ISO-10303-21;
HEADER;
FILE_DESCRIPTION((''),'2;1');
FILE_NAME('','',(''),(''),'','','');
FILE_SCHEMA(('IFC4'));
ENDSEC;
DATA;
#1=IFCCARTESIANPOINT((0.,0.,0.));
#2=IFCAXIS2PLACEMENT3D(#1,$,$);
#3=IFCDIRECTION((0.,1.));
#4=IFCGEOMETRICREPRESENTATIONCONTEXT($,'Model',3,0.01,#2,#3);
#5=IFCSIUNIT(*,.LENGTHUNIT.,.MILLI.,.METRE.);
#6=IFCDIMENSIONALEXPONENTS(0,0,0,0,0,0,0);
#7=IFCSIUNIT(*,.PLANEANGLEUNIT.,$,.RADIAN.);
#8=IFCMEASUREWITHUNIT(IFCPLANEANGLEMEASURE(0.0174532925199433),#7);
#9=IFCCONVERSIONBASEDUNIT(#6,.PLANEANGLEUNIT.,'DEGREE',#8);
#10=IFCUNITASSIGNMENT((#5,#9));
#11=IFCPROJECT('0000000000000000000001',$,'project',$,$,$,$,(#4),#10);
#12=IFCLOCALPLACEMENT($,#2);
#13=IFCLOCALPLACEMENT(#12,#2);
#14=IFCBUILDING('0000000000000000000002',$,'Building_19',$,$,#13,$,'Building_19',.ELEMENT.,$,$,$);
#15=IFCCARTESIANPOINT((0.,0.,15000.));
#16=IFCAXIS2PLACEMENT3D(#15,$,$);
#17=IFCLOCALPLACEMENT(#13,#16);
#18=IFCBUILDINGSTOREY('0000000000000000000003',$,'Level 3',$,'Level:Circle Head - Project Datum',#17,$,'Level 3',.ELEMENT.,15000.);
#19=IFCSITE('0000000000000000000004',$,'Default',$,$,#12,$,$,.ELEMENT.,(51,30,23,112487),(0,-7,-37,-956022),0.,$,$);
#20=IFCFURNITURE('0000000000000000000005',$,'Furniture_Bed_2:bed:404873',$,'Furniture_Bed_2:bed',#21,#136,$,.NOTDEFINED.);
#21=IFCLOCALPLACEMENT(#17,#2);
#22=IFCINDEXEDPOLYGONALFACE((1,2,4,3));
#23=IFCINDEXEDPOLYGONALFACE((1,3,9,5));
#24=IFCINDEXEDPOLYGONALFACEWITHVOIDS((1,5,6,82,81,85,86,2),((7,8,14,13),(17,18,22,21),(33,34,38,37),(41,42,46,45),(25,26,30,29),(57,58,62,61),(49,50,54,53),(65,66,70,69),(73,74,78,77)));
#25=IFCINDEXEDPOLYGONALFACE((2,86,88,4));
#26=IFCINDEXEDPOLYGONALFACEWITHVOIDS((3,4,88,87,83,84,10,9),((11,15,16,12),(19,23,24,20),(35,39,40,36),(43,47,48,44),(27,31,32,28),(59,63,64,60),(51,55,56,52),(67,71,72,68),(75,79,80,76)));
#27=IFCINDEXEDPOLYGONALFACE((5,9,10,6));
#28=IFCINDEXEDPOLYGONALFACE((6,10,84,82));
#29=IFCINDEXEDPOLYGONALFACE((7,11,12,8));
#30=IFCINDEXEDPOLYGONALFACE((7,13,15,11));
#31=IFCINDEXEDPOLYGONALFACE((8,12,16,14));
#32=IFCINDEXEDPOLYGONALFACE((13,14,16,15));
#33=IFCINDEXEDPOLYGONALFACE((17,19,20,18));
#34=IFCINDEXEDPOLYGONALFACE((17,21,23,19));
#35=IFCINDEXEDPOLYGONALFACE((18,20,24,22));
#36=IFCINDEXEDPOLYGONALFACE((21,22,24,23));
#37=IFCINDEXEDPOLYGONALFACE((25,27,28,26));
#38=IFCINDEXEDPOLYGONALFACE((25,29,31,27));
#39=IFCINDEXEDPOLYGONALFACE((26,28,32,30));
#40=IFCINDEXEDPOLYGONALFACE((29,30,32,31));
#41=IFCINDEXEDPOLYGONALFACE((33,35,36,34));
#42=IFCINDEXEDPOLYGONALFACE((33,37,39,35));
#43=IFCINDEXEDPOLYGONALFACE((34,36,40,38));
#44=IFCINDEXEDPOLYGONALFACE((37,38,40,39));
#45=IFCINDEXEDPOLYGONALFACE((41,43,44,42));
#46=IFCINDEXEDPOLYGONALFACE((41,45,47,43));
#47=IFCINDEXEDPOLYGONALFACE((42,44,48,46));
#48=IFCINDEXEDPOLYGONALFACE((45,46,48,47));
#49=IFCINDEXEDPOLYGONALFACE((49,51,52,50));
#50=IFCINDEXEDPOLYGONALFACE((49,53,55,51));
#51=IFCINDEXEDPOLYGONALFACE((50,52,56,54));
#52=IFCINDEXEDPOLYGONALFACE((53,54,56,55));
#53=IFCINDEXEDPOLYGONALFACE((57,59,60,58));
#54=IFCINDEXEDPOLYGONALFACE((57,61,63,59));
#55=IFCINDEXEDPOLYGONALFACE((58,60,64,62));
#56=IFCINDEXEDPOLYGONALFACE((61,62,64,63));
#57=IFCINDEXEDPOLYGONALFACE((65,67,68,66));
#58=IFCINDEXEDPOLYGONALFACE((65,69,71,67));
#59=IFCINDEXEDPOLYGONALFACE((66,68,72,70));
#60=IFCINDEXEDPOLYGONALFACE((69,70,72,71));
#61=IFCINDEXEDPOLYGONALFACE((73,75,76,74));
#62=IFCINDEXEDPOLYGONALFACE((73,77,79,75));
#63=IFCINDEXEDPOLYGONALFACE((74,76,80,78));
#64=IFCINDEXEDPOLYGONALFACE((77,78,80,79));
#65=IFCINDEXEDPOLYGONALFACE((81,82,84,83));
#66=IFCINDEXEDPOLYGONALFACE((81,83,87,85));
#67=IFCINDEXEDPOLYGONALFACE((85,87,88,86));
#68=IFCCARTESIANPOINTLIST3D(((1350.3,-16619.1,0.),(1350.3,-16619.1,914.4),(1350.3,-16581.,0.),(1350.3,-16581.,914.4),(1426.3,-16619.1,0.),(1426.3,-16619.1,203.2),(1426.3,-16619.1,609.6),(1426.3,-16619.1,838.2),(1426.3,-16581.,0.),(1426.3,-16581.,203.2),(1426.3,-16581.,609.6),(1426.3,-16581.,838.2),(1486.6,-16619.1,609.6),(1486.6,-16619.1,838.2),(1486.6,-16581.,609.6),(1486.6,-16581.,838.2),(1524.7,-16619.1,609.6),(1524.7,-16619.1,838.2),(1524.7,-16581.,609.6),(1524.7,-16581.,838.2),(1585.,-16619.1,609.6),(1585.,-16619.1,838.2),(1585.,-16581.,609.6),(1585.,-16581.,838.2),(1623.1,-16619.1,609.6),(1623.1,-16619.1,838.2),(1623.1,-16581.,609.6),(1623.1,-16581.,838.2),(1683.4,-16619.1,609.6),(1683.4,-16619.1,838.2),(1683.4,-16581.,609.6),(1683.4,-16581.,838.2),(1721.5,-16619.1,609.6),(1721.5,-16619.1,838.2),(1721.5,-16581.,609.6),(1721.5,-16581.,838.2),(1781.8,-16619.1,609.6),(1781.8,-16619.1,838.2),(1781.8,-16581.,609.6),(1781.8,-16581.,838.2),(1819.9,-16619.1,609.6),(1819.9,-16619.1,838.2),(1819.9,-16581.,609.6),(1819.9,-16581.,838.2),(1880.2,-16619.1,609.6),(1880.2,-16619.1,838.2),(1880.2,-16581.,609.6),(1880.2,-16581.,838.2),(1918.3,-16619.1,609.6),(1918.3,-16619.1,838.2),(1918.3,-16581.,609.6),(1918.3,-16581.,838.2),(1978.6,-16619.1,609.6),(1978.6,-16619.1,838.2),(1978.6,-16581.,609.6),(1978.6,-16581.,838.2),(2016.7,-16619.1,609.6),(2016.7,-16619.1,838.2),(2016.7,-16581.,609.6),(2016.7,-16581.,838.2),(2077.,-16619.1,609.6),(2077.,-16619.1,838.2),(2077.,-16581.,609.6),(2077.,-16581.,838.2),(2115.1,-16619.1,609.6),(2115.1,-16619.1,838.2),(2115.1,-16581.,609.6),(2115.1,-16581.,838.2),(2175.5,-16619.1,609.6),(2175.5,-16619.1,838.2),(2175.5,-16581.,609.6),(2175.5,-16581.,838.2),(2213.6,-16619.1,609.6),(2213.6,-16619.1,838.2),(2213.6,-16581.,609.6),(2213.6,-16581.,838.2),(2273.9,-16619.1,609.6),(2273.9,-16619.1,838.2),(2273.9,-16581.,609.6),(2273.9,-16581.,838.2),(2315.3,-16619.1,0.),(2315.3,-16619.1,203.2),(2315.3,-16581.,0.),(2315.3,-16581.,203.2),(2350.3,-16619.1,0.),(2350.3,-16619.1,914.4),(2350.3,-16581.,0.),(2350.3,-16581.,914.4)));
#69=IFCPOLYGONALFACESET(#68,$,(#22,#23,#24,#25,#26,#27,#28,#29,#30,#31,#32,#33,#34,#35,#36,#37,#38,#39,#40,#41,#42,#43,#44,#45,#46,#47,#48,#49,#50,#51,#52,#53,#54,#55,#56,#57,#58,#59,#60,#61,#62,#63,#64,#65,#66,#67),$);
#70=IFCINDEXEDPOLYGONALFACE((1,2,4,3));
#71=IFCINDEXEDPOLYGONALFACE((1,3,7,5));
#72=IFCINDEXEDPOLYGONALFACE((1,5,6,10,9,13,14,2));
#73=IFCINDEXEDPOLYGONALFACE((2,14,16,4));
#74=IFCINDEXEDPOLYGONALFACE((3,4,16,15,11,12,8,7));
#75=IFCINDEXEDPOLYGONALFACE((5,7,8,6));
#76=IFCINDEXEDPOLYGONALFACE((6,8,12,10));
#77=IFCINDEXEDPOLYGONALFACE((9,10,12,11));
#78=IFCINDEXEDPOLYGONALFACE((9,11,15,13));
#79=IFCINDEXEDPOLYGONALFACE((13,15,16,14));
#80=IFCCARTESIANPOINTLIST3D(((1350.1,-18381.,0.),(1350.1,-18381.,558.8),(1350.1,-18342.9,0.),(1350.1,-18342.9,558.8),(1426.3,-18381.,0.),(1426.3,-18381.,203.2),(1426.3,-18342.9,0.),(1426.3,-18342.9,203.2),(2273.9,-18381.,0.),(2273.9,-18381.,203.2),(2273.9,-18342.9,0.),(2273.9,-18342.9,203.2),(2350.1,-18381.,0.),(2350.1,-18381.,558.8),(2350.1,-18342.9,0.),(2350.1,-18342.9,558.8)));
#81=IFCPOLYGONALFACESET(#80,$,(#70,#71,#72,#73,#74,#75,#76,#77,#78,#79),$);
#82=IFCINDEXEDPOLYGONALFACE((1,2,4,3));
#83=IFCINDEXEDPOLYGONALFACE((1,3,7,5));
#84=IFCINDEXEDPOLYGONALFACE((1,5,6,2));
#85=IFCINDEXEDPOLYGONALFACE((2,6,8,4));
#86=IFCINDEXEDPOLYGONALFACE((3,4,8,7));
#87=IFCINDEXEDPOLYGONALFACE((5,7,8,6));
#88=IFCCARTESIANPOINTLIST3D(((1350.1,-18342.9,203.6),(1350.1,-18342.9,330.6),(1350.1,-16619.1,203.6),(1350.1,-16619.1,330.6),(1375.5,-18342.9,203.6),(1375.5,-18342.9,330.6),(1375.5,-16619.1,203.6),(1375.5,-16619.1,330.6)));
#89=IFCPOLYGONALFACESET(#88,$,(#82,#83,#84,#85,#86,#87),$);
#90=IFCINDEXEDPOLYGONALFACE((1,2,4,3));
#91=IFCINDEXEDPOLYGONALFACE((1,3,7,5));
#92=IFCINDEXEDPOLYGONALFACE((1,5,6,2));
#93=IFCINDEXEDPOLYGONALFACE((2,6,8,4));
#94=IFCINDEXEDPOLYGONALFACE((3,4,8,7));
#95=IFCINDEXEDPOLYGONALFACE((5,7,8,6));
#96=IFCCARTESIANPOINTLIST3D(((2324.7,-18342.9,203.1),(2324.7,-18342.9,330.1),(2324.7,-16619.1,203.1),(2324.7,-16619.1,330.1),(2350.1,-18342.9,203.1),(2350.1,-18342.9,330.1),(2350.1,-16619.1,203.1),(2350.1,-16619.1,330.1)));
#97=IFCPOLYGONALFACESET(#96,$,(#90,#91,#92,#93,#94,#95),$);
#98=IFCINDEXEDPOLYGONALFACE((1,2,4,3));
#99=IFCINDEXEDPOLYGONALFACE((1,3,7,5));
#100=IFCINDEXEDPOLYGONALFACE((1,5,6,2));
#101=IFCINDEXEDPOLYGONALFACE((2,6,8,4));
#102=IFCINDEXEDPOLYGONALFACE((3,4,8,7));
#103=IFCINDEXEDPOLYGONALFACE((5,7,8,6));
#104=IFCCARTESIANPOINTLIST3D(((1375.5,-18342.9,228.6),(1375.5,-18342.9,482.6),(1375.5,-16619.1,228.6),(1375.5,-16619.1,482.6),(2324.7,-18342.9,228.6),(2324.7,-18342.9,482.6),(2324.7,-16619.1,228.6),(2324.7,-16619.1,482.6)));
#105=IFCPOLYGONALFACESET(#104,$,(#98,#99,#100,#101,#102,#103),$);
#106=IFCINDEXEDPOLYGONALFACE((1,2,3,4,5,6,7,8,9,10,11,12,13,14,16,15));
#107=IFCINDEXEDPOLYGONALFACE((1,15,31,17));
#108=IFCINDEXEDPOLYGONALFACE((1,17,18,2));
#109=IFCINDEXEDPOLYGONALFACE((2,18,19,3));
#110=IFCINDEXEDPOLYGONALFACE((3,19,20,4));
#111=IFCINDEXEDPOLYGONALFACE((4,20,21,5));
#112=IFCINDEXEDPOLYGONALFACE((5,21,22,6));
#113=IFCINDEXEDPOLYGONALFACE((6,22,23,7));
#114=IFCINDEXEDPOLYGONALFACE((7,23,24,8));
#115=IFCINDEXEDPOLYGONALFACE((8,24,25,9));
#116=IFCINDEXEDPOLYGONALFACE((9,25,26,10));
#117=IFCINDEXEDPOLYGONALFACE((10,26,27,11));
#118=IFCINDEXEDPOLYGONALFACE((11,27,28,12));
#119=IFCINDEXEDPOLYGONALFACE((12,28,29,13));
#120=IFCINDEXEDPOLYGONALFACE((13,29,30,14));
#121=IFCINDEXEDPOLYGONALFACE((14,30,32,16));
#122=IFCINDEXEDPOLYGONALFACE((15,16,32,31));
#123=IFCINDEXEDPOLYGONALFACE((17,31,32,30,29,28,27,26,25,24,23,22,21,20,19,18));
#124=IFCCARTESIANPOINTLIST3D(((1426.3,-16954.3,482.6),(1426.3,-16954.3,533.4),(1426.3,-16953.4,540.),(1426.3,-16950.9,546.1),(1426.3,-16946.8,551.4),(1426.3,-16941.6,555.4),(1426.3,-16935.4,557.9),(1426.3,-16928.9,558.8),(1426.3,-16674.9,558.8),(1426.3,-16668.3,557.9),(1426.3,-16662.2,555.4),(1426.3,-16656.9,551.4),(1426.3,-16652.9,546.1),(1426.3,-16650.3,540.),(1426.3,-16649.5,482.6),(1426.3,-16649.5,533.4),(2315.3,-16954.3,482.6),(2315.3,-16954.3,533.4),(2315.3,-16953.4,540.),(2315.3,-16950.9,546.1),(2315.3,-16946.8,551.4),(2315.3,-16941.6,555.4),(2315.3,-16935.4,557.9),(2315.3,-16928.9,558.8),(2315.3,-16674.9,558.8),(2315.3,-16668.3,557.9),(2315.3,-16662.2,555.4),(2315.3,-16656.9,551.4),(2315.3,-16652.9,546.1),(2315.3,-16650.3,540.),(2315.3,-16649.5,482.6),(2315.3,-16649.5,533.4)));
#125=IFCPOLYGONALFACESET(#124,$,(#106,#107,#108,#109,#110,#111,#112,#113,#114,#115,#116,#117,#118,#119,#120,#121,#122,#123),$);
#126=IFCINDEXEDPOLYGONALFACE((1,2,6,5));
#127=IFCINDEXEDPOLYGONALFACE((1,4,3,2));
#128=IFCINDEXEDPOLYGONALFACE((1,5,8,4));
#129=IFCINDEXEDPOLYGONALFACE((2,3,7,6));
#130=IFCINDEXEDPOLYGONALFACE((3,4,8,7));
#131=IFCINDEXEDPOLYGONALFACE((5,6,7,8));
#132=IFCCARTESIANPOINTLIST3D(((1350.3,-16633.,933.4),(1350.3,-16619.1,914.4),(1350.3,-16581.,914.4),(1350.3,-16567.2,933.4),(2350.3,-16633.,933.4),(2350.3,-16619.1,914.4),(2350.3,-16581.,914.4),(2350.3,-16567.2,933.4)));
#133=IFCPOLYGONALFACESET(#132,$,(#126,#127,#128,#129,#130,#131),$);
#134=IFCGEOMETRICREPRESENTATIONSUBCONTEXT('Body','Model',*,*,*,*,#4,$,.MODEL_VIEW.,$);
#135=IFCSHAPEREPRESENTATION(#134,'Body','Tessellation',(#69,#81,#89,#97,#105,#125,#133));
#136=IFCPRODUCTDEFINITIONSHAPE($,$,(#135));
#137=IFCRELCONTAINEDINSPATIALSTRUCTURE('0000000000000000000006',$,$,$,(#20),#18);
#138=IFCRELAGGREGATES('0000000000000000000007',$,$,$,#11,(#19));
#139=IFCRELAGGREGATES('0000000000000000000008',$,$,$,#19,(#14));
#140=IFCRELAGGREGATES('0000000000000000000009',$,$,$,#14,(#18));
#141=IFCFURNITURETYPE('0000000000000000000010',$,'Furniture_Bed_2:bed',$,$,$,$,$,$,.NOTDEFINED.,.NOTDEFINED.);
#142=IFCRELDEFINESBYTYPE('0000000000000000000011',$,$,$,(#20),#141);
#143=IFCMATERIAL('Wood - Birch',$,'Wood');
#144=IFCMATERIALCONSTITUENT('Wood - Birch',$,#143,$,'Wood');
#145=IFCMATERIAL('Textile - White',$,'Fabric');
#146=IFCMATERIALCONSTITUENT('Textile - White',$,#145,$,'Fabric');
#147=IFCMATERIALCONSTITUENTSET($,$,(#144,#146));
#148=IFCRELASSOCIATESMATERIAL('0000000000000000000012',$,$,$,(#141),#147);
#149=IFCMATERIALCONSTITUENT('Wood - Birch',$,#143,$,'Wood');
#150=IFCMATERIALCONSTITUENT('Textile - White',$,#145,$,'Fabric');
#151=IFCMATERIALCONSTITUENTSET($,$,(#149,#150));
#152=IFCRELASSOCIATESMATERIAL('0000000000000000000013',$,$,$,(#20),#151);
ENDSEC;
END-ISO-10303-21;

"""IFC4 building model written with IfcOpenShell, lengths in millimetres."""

from ifc_helpers import new_model, entity, si_unit, converted_unit, direction, frame, origin, place, context, subcontext, project, spatial, line, arc, indexed_curve, outline, extrude, source, transform, mapped, material, constituent, constituent_set, type_object, type_shapes, element, save


model = new_model("IFC4")

# Units and contexts
model_context = context("Model", 3, precision=0.01, world=origin(), true_north=direction((0.0, 1.0)))
body_context = subcontext(model_context, "Body", "Model", "MODEL_VIEW")
ifc_project = project(units=[si_unit("LENGTHUNIT", "METRE", prefix="MILLI"), converted_unit("PLANEANGLEUNIT", "DEGREE", entity("IfcPlaneAngleMeasure", 0.0174532925199433), si_unit("PLANEANGLEUNIT", "RADIAN"), dimensions=[0, 0, 0, 0, 0, 0, 0])], contexts=[model_context])

# Site, building, storey
site_placement = place(None, origin())
site = spatial("IfcSite", under=ifc_project, at=site_placement, Name="Default", CompositionType="ELEMENT", RefLatitude=(51, 30, 23, 112487), RefLongitude=(0, -7, -37, -956022), RefElevation=0.0)
building_placement = place(site_placement, origin())
building = spatial("IfcBuilding", under=site, at=building_placement, Name="Building_19", LongName="Building_19", CompositionType="ELEMENT")
storey_placement = place(building_placement, frame((0.0, 0.0, 15000.0)))
storey = spatial("IfcBuildingStorey", under=building, at=storey_placement, Name="Level 3", ObjectType="Level:Circle Head - Project Datum", LongName="Level 3", CompositionType="ELEMENT", Elevation=15000.0)

# Furniture
ifc_material_1 = material(Name="Wood - Birch", Category="Wood")
ifc_material_2 = material(Name="Textile - White", Category="Fabric")
ifc_constituent_1 = constituent(ifc_material_1, Name="Wood - Birch", Category="Wood")
ifc_constituent_2 = constituent(ifc_material_2, Name="Textile - White", Category="Fabric")
ifc_constituent_set_1 = constituent_set(constituents=[ifc_constituent_1, ifc_constituent_2])
furniture_type_1 = type_object("IfcFurnitureType", Name="Furniture_Bed_2:bed", AssemblyPlace="NOTDEFINED", PredefinedType="NOTDEFINED", material=ifc_constituent_set_1)
shared_shape_1 = source(origin(), body_context, "Body", "SweptSolid", [
    extrude(outline(indexed_curve([(-635.0, -489.8), (279.4, -489.8), (279.4, -454.7), (76.2, -454.7), (76.2, 434.3), (279.4, 434.3), (279.4, 510.3), (-635.0, 510.3), (-635.0, -489.8)], self_intersect=False), holes=[indexed_curve([(-558.8, 374.0), (-558.8, 434.3), (-330.2, 434.3), (-330.2, 374.0), (-558.8, 374.0)], self_intersect=False), indexed_curve([(-558.8, 275.5), (-558.8, 335.9), (-330.2, 335.9), (-330.2, 275.5), (-558.8, 275.5)], self_intersect=False), indexed_curve([(-558.8, 177.1), (-558.8, 237.4), (-330.2, 237.4), (-330.2, 177.1), (-558.8, 177.1)], self_intersect=False), indexed_curve([(-558.8, 78.7), (-558.8, 139.0), (-330.2, 139.0), (-330.2, 78.7), (-558.8, 78.7)], self_intersect=False), indexed_curve([(-558.8, -118.1), (-558.8, -57.8), (-330.2, -57.8), (-330.2, -118.1), (-558.8, -118.1)], self_intersect=False), indexed_curve([(-558.8, -216.5), (-558.8, -156.2), (-330.2, -156.2), (-330.2, -216.5), (-558.8, -216.5)], self_intersect=False), indexed_curve([(-558.8, -314.9), (-558.8, -254.6), (-330.2, -254.6), (-330.2, -314.9), (-558.8, -314.9)], self_intersect=False), indexed_curve([(-558.8, -413.3), (-558.8, -353.0), (-330.2, -353.0), (-330.2, -413.3), (-558.8, -413.3)], self_intersect=False), indexed_curve([(-558.8, -19.7), (-558.8, 40.6), (-330.2, 40.6), (-330.2, -19.7), (-558.8, -19.7)], self_intersect=False)]), frame((-8.6, -38.1, 279.4), z_axis=(0.0, 1.0, 0.0), x_axis=(0.0, 0.0, -1.0)), (0.0, 0.0, 1.0), 38.1),
    extrude(outline(indexed_curve([(423.8, -190.5), (500.0, -190.5), (500.0, 368.3), (-500.0, 368.3), (-500.0, -190.5), (-423.8, -190.5), (-423.8, 12.7), (423.8, 12.7), (423.8, -190.5)], self_intersect=False)), frame((-19.1, -1800.0, 190.5), z_axis=(0.0, 1.0, 0.0), x_axis=(-1.0, 0.0, 0.0)), (0.0, 0.0, 1.0), 38.1),
    extrude(outline(indexed_curve([(-12.7, -861.9), (12.7, -861.9), (12.7, 861.9), (-12.7, 861.9), (-12.7, -861.9)], self_intersect=False)), frame((-506.4, -900.0, 203.6)), (0.0, 0.0, 1.0), 127.0),
    extrude(outline(indexed_curve([(-12.7, -861.9), (12.7, -861.9), (12.7, 861.9), (-12.7, 861.9), (-12.7, -861.9)], self_intersect=False)), frame((468.2, -900.0, 203.1)), (0.0, 0.0, 1.0), 127.0),
    extrude(outline(indexed_curve([(-474.6, -861.9), (474.6, -861.9), (474.6, 861.9), (-474.6, 861.9), (-474.6, -861.9)], self_intersect=False)), frame((-19.0, -900.0, 228.6), z_axis=(0.0, 0.0, 1.0), x_axis=(-1.0, 0.0, 0.0)), (0.0, 0.0, 1.0), 254.0),
    extrude(outline(indexed_curve([(-152.4, -42.3), (152.4, -42.3), (152.4, 8.5), (145.0, 26.4), (127.0, 33.9), (-127.0, 33.9), (-145.0, 26.4), (-152.4, 8.5)], segments=[line(1, 2, 3), arc(3, 4, 5), line(5, 6), arc(6, 7, 8), line(8, 1)], self_intersect=False)), frame((-442.9, -220.8, 524.9), z_axis=(1.0, 0.0, 0.0), x_axis=(0.0, 1.0, 0.0)), (0.0, 0.0, 1.0), 889.0),
    extrude(outline(indexed_curve([(-19.1, -9.5), (19.0, -9.5), (32.9, 9.5), (-32.9, 9.5), (-19.1, -9.5)], self_intersect=False)), frame((-518.8, -19.0, 923.9), z_axis=(1.0, 0.0, 0.0), x_axis=(0.0, 1.0, 0.0)), (0.0, 0.0, 1.0), 1000.1),
])
type_shapes(furniture_type_1, [shared_shape_1])
ifc_constituent_3 = constituent(ifc_material_1, Name="Wood - Birch", Category="Wood")
ifc_constituent_4 = constituent(ifc_material_2, Name="Textile - White", Category="Fabric")
ifc_constituent_set_2 = constituent_set(constituents=[ifc_constituent_3, ifc_constituent_4])
furniture_1_placement = place(storey_placement, frame((1869.1, -16581.0, 0.0)))
element("IfcFurniture", 1, at=furniture_1_placement, inside=storey, type_object=furniture_type_1, material=ifc_constituent_set_2, Name="Furniture_Bed_2:bed:404873", ObjectType="Furniture_Bed_2:bed", PredefinedType="NOTDEFINED", context=body_context, shape_type="MappedRepresentation", body=[
    mapped(shared_shape_1, transform((0.0, 0.0, 0.0), scale=1.0)),
])

save(model, "model.ifc")
